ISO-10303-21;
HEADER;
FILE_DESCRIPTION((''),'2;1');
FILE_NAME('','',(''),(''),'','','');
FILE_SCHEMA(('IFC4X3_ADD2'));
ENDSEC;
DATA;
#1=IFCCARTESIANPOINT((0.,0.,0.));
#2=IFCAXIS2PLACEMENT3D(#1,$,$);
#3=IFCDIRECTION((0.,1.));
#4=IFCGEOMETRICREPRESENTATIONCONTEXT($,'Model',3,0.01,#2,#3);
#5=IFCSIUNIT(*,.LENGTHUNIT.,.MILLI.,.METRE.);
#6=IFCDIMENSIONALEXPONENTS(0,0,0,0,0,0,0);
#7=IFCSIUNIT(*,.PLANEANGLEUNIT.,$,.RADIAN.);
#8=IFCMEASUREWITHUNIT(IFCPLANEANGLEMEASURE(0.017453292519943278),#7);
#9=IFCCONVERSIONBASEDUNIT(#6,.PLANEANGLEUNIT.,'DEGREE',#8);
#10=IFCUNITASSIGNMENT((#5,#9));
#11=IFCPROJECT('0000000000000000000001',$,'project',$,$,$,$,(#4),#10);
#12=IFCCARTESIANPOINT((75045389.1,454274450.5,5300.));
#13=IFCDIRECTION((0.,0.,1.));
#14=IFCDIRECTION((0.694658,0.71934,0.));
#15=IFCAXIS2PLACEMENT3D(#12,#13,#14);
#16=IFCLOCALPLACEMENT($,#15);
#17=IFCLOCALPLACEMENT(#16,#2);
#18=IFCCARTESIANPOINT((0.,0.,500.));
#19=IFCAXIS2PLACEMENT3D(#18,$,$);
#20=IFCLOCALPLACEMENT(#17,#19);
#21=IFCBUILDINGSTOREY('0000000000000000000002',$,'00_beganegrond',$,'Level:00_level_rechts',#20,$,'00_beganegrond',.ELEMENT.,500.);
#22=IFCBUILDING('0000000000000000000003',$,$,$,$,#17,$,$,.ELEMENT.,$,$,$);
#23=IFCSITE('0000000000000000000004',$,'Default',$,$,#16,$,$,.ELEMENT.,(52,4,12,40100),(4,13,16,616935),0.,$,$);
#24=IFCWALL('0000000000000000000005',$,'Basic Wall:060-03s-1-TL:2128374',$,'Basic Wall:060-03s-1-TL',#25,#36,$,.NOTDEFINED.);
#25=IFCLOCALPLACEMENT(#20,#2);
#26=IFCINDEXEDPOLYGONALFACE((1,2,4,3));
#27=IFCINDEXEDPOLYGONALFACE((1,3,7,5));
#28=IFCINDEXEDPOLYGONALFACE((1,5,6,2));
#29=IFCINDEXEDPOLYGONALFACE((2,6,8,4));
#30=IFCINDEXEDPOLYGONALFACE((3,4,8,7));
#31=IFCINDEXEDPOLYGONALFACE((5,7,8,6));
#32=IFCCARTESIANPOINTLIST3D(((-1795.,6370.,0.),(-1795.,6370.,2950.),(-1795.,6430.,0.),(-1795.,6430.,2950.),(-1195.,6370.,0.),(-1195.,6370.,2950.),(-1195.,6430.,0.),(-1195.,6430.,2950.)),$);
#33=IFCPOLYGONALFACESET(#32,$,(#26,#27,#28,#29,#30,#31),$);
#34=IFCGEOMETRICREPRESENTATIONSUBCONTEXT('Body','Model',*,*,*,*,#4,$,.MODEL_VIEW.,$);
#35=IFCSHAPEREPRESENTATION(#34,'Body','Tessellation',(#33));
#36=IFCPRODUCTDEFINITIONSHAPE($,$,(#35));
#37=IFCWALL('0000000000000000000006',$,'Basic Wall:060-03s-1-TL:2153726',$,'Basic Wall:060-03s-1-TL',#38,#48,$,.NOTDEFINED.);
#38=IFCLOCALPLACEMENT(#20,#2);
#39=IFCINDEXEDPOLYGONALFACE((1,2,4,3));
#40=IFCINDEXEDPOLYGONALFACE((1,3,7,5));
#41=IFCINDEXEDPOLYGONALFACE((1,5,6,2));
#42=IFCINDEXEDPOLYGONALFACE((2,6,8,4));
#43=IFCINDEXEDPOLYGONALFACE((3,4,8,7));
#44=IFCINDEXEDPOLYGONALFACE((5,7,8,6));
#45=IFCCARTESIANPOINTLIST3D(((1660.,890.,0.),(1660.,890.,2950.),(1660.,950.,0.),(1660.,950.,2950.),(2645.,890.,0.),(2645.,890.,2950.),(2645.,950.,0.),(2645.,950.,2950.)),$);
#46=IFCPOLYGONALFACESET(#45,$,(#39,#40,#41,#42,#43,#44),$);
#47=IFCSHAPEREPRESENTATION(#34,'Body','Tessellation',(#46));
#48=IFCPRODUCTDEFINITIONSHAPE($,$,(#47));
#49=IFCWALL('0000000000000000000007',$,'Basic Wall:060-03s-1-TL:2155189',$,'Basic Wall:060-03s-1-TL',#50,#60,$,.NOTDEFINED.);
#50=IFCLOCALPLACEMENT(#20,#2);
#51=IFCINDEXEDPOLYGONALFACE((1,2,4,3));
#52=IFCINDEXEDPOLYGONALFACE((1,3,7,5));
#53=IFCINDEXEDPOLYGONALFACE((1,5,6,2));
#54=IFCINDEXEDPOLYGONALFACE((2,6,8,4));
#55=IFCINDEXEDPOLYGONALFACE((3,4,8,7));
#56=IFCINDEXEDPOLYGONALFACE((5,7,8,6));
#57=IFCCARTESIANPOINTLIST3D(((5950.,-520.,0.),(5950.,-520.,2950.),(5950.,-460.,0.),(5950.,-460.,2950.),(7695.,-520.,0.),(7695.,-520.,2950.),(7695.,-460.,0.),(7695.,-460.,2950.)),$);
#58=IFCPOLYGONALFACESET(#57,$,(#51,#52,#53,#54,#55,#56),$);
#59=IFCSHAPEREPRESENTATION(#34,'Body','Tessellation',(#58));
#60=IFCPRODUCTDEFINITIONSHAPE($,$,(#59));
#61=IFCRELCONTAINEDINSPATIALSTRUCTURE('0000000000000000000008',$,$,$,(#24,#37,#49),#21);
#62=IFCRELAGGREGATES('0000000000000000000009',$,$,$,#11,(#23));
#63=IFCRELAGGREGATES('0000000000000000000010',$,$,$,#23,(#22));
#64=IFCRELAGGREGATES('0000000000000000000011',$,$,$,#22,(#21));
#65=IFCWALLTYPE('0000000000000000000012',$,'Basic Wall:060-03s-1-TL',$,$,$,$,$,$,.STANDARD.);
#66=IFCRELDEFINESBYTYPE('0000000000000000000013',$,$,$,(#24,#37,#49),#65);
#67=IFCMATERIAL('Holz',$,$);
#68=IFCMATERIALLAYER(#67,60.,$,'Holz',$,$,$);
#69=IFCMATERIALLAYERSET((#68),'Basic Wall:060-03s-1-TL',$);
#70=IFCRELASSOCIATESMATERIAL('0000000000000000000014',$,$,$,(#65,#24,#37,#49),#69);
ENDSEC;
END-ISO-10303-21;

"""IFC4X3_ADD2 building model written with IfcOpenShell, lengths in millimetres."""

from ifc_helpers import new_model, entity, si_unit, converted_unit, direction, frame, frame_2d, origin, place, context, subcontext, project, spatial, rectangle, extrude, material, layer, layer_set, type_object, element, save


model = new_model("IFC4X3_ADD2")

# Units and contexts
model_context = context("Model", 3, precision=0.01, world=origin(), true_north=direction((0.0, 1.0)))
body_context = subcontext(model_context, "Body", "Model", "MODEL_VIEW")
ifc_project = project(units=[si_unit("LENGTHUNIT", "METRE", prefix="MILLI"), converted_unit("PLANEANGLEUNIT", "DEGREE", entity("IfcPlaneAngleMeasure", 0.017453292519943278), si_unit("PLANEANGLEUNIT", "RADIAN"), dimensions=[0, 0, 0, 0, 0, 0, 0])], contexts=[model_context])

# Site, building, storey
site_placement = place(None, frame((75045389.1, 454274450.5, 5300.0), z_axis=(0.0, 0.0, 1.0), x_axis=(0.694658, 0.71934, 0.0)))
site = spatial("IfcSite", under=ifc_project, at=site_placement, Name="Default", CompositionType="ELEMENT", RefLatitude=(52, 4, 12, 40100), RefLongitude=(4, 13, 16, 616935), RefElevation=0.0)
building_placement = place(site_placement, origin())
building = spatial("IfcBuilding", under=site, at=building_placement, CompositionType="ELEMENT")
storey_placement = place(building_placement, frame((0.0, 0.0, 500.0)))
storey = spatial("IfcBuildingStorey", under=building, at=storey_placement, Name="00_beganegrond", ObjectType="Level:00_level_rechts", LongName="00_beganegrond", CompositionType="ELEMENT", Elevation=500.0)

# Shared definitions
ifc_material_1 = material(Name="Holz")

# Walls
ifc_layer_1 = layer(ifc_material_1, 60.0, Name="Holz")
ifc_layer_set_1 = layer_set([ifc_layer_1], Name="Basic Wall:060-03s-1-TL")
wall_type = type_object("IfcWallType", Name="Basic Wall:060-03s-1-TL", PredefinedType="STANDARD", material=ifc_layer_set_1)
wall_1_placement = place(storey_placement, frame((-1195.0, 6400.0, 0.0), z_axis=(0.0, 0.0, 1.0), x_axis=(-1.0, 0.0, 0.0)))
element("IfcWall", 1, at=wall_1_placement, inside=storey, type_object=wall_type, material=ifc_layer_set_1, Name="Basic Wall:060-03s-1-TL:2128374", ObjectType="Basic Wall:060-03s-1-TL", PredefinedType="NOTDEFINED", context=body_context, shape_type="SweptSolid", body=[
    extrude(rectangle(XDim=600.0, YDim=60.0, at=frame_2d((300.0, 0.0), x_axis=(-1.0, 0.0))), origin(), (0.0, 0.0, 1.0), 2950.0),
])
wall_2_placement = place(storey_placement, frame((1660.0, 920.0, 0.0)))
element("IfcWall", 2, at=wall_2_placement, inside=storey, type_object=wall_type, material=ifc_layer_set_1, Name="Basic Wall:060-03s-1-TL:2153726", ObjectType="Basic Wall:060-03s-1-TL", PredefinedType="NOTDEFINED", context=body_context, shape_type="SweptSolid", body=[
    extrude(rectangle(XDim=985.0, YDim=60.0, at=frame_2d((492.5, 0.0), x_axis=(-1.0, 0.0))), origin(), (0.0, 0.0, 1.0), 2950.0),
])
wall_3_placement = place(storey_placement, frame((5950.0, -490.0, 0.0)))
element("IfcWall", 3, at=wall_3_placement, inside=storey, type_object=wall_type, material=ifc_layer_set_1, Name="Basic Wall:060-03s-1-TL:2155189", ObjectType="Basic Wall:060-03s-1-TL", PredefinedType="NOTDEFINED", context=body_context, shape_type="SweptSolid", body=[
    extrude(rectangle(XDim=1745.0, YDim=60.0, at=frame_2d((872.5, 0.0), x_axis=(-1.0, 0.0))), origin(), (0.0, 0.0, 1.0), 2950.0),
])

save(model, "model.ifc")
